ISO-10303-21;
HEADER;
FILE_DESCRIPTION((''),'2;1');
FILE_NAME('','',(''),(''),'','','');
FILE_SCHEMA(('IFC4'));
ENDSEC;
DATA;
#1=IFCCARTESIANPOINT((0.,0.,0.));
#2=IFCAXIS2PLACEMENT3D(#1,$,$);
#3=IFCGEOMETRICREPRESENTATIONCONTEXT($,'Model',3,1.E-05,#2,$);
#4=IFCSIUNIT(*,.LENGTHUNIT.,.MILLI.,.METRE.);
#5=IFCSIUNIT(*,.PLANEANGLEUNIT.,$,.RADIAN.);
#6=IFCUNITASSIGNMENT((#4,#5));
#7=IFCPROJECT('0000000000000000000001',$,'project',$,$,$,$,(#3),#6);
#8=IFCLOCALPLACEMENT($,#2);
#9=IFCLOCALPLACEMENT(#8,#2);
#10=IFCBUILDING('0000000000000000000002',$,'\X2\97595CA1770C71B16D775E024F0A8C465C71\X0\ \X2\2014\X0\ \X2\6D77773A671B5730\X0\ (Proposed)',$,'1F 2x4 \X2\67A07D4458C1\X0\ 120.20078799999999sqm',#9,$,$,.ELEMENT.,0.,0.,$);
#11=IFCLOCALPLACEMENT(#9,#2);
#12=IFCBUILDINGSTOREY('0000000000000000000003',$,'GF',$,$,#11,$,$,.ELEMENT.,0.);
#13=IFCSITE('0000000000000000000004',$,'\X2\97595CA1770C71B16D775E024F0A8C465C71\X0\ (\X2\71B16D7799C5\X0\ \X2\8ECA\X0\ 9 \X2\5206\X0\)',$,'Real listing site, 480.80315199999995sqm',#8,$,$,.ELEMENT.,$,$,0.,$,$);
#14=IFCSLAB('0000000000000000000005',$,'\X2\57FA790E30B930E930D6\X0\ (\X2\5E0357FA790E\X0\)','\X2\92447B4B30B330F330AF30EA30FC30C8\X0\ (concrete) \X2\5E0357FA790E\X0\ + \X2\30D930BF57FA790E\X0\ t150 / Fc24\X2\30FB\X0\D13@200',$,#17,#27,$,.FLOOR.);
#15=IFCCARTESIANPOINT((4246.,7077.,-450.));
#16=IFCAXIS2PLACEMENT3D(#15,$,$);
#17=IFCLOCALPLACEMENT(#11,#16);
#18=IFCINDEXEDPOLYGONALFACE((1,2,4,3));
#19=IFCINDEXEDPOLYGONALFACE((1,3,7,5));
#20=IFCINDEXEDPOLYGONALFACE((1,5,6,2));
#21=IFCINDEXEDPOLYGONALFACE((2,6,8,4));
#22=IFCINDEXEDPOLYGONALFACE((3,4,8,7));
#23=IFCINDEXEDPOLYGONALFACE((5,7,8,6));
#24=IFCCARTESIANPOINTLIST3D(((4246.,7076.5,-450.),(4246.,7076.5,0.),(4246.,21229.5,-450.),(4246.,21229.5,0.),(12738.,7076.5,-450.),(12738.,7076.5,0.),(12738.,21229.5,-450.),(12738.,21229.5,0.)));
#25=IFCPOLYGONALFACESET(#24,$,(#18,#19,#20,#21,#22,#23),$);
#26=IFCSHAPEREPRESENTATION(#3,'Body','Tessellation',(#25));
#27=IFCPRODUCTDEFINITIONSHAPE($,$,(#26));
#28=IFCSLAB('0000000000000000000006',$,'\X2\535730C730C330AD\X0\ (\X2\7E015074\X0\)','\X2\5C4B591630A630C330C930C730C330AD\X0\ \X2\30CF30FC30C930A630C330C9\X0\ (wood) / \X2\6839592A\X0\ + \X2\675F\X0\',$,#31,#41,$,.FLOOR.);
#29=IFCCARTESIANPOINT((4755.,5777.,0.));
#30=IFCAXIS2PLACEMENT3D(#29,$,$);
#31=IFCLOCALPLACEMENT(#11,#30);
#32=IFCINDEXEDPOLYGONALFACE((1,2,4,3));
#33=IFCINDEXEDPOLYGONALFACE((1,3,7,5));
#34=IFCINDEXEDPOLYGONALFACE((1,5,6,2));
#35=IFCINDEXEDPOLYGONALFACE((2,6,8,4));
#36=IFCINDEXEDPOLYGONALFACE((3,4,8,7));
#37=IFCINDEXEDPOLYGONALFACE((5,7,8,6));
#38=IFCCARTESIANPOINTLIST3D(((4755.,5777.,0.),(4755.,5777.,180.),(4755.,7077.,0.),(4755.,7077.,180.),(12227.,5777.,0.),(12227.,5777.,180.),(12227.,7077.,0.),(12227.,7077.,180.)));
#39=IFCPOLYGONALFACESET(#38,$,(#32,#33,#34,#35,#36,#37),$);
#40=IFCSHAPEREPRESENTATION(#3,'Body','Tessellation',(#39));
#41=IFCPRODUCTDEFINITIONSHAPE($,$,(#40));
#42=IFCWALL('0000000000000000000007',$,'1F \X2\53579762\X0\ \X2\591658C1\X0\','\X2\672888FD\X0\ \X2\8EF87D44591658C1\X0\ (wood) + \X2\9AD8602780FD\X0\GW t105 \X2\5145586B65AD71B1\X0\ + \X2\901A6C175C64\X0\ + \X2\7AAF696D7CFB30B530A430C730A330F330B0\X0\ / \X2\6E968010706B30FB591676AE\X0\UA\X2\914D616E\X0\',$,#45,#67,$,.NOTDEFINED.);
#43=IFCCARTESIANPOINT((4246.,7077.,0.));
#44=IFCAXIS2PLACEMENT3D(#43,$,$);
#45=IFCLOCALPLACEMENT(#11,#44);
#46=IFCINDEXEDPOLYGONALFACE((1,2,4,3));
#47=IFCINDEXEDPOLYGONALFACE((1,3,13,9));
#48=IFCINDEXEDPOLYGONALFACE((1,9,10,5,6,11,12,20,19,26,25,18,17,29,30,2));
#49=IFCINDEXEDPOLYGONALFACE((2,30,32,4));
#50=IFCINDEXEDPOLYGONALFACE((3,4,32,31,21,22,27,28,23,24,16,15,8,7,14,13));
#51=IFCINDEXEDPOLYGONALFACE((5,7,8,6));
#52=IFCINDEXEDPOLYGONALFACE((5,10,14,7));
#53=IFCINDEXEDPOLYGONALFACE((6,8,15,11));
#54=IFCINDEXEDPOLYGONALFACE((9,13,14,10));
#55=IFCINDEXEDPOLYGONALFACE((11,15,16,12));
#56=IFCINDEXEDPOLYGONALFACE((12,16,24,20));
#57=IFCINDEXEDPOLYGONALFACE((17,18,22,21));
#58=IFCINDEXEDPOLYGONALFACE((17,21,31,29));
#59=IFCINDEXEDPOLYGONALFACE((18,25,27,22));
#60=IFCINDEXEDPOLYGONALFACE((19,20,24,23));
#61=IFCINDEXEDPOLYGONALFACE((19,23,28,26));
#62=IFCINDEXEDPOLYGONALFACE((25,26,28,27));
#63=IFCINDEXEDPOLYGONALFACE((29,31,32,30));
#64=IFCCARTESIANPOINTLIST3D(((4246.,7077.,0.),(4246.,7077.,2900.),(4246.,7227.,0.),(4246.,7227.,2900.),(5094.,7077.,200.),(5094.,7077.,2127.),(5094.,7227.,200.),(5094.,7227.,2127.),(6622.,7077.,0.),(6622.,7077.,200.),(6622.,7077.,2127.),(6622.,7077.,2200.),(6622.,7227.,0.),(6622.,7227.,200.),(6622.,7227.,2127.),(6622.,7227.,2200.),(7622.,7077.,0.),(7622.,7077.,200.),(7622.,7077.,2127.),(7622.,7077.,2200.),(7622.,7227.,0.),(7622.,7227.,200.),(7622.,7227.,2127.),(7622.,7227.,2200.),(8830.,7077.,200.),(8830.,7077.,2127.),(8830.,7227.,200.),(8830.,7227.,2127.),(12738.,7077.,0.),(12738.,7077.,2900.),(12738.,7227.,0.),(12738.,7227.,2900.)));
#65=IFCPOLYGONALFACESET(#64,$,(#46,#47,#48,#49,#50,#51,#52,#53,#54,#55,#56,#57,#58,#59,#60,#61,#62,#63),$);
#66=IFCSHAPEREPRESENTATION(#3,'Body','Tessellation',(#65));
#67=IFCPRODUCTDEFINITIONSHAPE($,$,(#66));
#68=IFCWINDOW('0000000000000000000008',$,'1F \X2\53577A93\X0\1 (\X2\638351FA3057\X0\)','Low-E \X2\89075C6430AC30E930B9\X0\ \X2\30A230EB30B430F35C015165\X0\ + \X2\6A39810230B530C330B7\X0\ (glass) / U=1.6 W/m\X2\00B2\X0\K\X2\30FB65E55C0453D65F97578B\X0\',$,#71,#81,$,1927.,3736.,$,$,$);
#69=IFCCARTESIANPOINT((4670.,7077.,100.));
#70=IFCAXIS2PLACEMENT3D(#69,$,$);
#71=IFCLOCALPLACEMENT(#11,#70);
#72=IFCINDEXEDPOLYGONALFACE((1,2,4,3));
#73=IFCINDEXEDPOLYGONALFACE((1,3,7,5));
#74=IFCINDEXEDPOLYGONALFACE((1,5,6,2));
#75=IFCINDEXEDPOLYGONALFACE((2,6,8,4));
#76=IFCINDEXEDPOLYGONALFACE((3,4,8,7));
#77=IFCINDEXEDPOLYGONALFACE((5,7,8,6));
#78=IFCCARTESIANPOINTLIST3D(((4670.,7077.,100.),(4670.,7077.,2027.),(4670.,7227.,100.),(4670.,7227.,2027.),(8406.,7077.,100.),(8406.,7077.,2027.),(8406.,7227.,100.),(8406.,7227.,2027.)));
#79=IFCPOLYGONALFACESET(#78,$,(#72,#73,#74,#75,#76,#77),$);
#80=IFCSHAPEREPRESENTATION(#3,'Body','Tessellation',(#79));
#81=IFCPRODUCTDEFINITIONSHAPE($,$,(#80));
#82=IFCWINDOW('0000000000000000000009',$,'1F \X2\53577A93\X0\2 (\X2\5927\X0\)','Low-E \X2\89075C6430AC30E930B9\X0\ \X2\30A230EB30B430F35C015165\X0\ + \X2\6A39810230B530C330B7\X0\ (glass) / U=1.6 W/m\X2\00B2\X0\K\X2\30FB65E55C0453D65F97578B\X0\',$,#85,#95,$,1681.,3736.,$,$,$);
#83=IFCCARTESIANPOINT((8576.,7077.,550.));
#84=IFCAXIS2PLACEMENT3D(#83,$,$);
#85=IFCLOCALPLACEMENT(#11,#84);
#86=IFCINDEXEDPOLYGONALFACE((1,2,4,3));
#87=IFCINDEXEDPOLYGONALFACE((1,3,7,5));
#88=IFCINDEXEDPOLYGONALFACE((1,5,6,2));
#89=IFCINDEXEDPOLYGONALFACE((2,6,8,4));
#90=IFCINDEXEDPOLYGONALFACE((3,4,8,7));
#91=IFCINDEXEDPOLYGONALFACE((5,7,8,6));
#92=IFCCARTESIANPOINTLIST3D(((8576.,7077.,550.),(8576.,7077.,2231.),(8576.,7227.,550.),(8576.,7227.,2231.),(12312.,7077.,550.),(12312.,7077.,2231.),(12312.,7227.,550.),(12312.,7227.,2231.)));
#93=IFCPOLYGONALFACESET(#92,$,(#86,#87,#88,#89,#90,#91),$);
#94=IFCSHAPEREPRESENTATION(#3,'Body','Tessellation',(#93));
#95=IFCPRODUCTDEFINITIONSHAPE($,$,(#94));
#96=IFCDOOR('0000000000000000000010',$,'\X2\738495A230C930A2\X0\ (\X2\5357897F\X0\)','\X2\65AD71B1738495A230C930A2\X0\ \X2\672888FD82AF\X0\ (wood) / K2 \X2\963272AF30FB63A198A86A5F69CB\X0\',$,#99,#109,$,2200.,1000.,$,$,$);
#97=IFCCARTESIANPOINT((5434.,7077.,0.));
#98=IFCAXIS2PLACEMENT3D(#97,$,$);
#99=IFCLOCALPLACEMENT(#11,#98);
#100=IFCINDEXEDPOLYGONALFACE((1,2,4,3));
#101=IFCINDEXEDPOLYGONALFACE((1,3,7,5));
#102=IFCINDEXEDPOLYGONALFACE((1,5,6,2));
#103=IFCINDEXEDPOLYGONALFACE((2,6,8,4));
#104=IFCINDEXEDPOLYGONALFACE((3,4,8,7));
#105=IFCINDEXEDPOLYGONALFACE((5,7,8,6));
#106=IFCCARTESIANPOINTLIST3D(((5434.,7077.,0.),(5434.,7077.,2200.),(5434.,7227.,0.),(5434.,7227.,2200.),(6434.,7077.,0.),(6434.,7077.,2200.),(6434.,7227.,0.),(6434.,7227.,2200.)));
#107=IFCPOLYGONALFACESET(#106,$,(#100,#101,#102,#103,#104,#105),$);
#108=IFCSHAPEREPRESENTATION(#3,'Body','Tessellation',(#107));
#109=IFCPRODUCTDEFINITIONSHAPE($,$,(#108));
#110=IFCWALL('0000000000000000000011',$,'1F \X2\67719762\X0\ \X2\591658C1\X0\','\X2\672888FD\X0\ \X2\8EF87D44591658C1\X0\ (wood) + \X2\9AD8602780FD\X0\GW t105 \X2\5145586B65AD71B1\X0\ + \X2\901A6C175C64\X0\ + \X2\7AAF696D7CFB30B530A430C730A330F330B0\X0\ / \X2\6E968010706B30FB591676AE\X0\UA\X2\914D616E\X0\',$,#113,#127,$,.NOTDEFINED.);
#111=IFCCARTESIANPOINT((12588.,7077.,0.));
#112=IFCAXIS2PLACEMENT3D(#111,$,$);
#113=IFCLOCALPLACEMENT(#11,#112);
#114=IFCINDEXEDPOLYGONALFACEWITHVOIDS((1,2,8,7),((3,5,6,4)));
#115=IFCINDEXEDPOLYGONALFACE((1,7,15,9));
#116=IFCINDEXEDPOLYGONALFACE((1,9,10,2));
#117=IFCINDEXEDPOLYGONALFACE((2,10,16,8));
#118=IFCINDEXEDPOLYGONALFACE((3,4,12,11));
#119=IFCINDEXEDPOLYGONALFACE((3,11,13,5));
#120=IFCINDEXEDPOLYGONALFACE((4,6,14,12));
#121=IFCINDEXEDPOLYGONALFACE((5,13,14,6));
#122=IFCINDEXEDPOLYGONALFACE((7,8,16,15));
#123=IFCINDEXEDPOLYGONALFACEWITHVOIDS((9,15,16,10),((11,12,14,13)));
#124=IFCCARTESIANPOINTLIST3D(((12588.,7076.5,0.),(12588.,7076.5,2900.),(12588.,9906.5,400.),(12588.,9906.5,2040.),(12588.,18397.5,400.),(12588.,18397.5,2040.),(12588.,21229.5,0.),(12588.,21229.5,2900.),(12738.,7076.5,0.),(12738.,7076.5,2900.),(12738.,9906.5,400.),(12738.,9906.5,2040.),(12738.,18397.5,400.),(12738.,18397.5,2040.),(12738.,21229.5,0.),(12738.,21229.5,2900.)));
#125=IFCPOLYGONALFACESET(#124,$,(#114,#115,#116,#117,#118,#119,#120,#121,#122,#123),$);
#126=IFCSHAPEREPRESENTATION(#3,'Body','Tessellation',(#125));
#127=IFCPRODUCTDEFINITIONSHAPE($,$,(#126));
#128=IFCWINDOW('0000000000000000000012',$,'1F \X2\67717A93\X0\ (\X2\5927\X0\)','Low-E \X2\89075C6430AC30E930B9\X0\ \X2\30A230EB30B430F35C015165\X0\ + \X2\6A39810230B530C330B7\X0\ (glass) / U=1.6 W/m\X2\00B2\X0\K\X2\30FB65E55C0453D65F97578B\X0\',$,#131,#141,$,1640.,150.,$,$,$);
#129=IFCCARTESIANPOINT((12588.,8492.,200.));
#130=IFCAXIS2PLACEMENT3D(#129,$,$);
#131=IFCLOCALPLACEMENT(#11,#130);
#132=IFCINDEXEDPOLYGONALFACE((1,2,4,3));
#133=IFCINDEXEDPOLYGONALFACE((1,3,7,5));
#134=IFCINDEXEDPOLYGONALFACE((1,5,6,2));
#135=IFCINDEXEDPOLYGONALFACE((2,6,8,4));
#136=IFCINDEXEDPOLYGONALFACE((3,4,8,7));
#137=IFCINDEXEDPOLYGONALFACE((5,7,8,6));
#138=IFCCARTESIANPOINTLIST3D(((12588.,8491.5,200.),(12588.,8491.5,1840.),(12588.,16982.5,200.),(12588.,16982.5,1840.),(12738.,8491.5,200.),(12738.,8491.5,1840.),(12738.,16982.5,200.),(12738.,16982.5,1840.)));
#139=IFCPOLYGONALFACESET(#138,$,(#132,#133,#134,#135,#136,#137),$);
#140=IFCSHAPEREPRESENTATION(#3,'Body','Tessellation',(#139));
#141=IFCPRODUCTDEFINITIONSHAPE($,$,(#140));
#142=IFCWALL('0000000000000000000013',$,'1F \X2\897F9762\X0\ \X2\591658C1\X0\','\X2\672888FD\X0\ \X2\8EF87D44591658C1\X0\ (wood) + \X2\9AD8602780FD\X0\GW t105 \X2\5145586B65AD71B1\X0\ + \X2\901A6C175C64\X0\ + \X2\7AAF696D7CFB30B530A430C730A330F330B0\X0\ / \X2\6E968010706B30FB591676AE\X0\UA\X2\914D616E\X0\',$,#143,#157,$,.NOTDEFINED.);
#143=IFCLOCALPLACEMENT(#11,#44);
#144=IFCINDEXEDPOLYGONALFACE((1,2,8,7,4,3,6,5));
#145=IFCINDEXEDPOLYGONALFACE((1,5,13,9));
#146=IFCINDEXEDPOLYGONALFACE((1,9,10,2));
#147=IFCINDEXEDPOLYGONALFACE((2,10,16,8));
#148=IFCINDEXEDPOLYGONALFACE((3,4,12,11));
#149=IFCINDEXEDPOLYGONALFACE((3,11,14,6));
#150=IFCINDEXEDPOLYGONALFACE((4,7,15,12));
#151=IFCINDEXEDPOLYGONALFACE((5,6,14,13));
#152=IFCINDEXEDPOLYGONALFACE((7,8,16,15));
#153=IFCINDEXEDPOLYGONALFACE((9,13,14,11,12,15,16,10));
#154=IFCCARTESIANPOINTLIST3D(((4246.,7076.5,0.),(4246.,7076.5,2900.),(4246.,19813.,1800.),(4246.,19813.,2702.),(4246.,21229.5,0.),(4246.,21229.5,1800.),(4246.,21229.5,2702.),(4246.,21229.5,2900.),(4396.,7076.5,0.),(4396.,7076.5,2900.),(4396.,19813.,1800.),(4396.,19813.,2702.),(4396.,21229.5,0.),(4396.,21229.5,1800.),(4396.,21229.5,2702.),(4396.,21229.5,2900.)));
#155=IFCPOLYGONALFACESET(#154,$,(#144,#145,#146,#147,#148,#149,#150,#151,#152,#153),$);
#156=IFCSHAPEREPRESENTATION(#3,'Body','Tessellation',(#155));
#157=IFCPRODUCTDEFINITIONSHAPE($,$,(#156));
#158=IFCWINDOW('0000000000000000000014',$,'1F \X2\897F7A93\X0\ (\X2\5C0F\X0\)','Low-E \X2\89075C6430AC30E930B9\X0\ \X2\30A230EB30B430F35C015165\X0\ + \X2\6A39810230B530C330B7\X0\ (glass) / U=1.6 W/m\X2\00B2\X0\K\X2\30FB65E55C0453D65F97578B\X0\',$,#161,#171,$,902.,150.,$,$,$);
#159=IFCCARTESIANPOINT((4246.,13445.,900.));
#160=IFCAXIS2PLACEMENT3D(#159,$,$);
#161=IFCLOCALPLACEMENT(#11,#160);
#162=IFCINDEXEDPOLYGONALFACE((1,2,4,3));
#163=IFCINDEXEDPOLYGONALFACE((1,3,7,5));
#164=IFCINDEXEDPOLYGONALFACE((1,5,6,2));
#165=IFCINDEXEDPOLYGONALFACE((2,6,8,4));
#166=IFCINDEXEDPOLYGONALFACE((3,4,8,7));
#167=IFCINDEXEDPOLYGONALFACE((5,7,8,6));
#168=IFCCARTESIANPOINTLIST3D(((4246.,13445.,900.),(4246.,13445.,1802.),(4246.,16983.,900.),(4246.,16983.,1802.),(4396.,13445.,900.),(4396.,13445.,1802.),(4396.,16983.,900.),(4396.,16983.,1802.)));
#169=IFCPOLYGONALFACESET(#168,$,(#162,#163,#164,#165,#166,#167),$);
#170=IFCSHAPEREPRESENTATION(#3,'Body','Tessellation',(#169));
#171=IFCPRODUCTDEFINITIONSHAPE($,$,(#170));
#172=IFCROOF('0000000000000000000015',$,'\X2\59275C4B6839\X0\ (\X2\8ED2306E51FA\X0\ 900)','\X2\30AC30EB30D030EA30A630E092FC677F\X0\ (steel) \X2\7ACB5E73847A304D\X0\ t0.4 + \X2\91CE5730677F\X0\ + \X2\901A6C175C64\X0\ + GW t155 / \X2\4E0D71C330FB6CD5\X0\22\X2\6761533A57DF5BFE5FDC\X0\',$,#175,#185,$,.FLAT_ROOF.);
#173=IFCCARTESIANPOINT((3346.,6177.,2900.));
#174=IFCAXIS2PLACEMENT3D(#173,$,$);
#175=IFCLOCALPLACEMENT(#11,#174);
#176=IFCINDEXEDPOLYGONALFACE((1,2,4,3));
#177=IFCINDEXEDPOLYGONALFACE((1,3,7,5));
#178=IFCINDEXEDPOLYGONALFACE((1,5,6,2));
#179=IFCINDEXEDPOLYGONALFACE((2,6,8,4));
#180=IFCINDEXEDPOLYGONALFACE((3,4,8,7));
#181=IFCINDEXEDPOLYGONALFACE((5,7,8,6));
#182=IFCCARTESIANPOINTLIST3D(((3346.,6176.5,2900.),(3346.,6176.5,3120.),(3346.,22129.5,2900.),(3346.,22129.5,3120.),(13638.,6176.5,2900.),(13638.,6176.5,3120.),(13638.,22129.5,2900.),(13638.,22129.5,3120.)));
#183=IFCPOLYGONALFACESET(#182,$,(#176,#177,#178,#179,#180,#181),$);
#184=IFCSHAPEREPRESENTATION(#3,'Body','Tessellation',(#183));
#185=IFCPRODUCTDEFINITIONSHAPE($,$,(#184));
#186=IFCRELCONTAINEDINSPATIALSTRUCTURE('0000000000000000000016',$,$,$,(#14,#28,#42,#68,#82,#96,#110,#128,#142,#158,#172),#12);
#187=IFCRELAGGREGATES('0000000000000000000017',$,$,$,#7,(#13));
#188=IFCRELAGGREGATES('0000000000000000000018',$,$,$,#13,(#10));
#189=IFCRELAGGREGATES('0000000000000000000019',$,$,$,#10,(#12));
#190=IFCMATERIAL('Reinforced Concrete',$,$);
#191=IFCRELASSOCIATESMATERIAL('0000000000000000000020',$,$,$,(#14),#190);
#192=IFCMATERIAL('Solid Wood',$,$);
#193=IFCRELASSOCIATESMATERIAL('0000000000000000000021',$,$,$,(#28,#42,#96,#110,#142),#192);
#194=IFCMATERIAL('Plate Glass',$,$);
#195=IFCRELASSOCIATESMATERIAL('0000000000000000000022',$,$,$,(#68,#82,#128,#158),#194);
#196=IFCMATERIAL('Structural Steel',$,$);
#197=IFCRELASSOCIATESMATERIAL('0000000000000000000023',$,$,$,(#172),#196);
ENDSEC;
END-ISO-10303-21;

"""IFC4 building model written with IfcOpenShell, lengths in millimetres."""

from ifc_helpers import new_model, si_unit, frame, frame_2d, origin, place, context, project, spatial, rectangle, extrude, material, element, fill, save


model = new_model("IFC4")

# Units and contexts
model_context = context("Model", 3, precision=1e-05, world=origin())
ifc_project = project(units=[si_unit("LENGTHUNIT", "METRE", prefix="MILLI"), si_unit("PLANEANGLEUNIT", "RADIAN")], contexts=[model_context])

# Site, building, storey
site_placement = place(None, origin())
site = spatial("IfcSite", under=ifc_project, at=site_placement, Name="静岡県熱海市伊豆山 (熱海駅 車 9 分)", ObjectType="Real listing site, 480.80315199999995sqm", CompositionType="ELEMENT", RefElevation=0.0)
building_placement = place(site_placement, origin())
building = spatial("IfcBuilding", under=site, at=building_placement, Name="静岡県熱海市伊豆山 — 海眺望地 (Proposed)", ObjectType="1F 2x4 枠組壁 120.20078799999999sqm", CompositionType="ELEMENT", ElevationOfRefHeight=0.0, ElevationOfTerrain=0.0)
storey_placement = place(building_placement, origin())
storey = spatial("IfcBuildingStorey", under=building, at=storey_placement, Name="GF", CompositionType="ELEMENT", Elevation=0.0)

# Slabs
ifc_material_1 = material(Name="Reinforced Concrete")
slab_1_placement = place(storey_placement, frame((4246.0, 7077.0, -450.0)))
element("IfcSlab", 1, at=slab_1_placement, inside=storey, material=ifc_material_1, Name="基礎スラブ (布基礎)", Description="鉄筋コンクリート (concrete) 布基礎 + ベタ基礎 t150 / Fc24・D13@200", PredefinedType="FLOOR", context=model_context, shape_type="SweptSolid", body=[
    extrude(rectangle(XDim=8492.0, YDim=14153.0, at=frame_2d((4246.0, 7076.0))), frame((4246.0, 7077.0, -450.0)), (0.0, 0.0, 1.0), 450.0),
])
ifc_material_2 = material(Name="Solid Wood")
slab_2_placement = place(storey_placement, frame((4755.0, 5777.0, 0.0)))
element("IfcSlab", 2, at=slab_2_placement, inside=storey, material=ifc_material_2, Name="南デッキ (縁側)", Description="屋外ウッドデッキ ハードウッド (wood) / 根太 + 束", PredefinedType="FLOOR", context=model_context, shape_type="SweptSolid", body=[
    extrude(rectangle(XDim=7472.0, YDim=1300.0, at=frame_2d((3736.0, 650.0))), frame((4755.0, 5777.0, 0.0)), (0.0, 0.0, 1.0), 180.0),
])

# Wall, openings, windows, door
wall_1_placement = place(storey_placement, frame((4246.0, 7077.0, 0.0)))
wall_1 = element("IfcWall", 3, at=wall_1_placement, inside=storey, material=ifc_material_2, Name="1F 南面 外壁", Description="木製 軸組外壁 (wood) + 高性能GW t105 充填断熱 + 通気層 + 窯業系サイディング / 準耐火・外皮UA配慮", PredefinedType="NOTDEFINED", context=model_context, shape_type="SweptSolid", body=[
    extrude(rectangle(XDim=8492.0, YDim=150.0, at=frame_2d((4246.0, 75.0))), frame((4246.0, 7077.0, 0.0)), (0.0, 0.0, 1.0), 2900.0),
])
opening_1_placement = place(storey_placement, frame((4670.0, 7077.0, 100.0)))
opening_1 = element("IfcOpeningElement", 4, at=opening_1_placement, cuts=wall_1, PredefinedType="NOTDEFINED", context=model_context, shape_type="SweptSolid", body=[
    extrude(rectangle(XDim=3736.0, YDim=150.0, at=frame_2d((1868.0, 75.0))), frame((4670.0, 7077.0, 100.0)), (0.0, 0.0, 1.0), 1927.0),
])
opening_2_placement = place(storey_placement, frame((8576.0, 7077.0, 550.0)))
opening_2 = element("IfcOpeningElement", 5, at=opening_2_placement, cuts=wall_1, PredefinedType="NOTDEFINED", context=model_context, shape_type="SweptSolid", body=[
    extrude(rectangle(XDim=3736.0, YDim=150.0, at=frame_2d((1868.0, 75.0))), frame((8576.0, 7077.0, 550.0)), (0.0, 0.0, 1.0), 1681.0),
])
opening_3_placement = place(storey_placement, frame((5434.0, 7077.0, 0.0)))
opening_3 = element("IfcOpeningElement", 6, at=opening_3_placement, cuts=wall_1, PredefinedType="NOTDEFINED", context=model_context, shape_type="SweptSolid", body=[
    extrude(rectangle(XDim=1000.0, YDim=150.0, at=frame_2d((500.0, 75.0))), frame((5434.0, 7077.0, 0.0)), (0.0, 0.0, 1.0), 2200.0),
])
ifc_material_3 = material(Name="Plate Glass")
window_1_placement = place(storey_placement, frame((4670.0, 7077.0, 100.0)))
window_1 = element("IfcWindow", 7, at=window_1_placement, inside=storey, material=ifc_material_3, Name="1F 南窓1 (掃出し)", Description="Low-E 複層ガラス アルゴン封入 + 樹脂サッシ (glass) / U=1.6 W/m²K・日射取得型", OverallHeight=1927.0, OverallWidth=3736.0, context=model_context, shape_type="SweptSolid", body=[
    extrude(rectangle(XDim=3736.0, YDim=150.0, at=frame_2d((1868.0, 75.0))), frame((4670.0, 7077.0, 100.0)), (0.0, 0.0, 1.0), 1927.0),
])
fill(opening_1, window_1)
window_2_placement = place(storey_placement, frame((8576.0, 7077.0, 550.0)))
window_2 = element("IfcWindow", 8, at=window_2_placement, inside=storey, material=ifc_material_3, Name="1F 南窓2 (大)", Description="Low-E 複層ガラス アルゴン封入 + 樹脂サッシ (glass) / U=1.6 W/m²K・日射取得型", OverallHeight=1681.0, OverallWidth=3736.0, context=model_context, shape_type="SweptSolid", body=[
    extrude(rectangle(XDim=3736.0, YDim=150.0, at=frame_2d((1868.0, 75.0))), frame((8576.0, 7077.0, 550.0)), (0.0, 0.0, 1.0), 1681.0),
])
fill(opening_2, window_2)
door_placement = place(storey_placement, frame((5434.0, 7077.0, 0.0)))
door = element("IfcDoor", 9, at=door_placement, inside=storey, material=ifc_material_2, Name="玄関ドア (南西)", Description="断熱玄関ドア 木製芯 (wood) / K2 防犯・採風機構", OverallHeight=2200.0, OverallWidth=1000.0, context=model_context, shape_type="SweptSolid", body=[
    extrude(rectangle(XDim=1000.0, YDim=150.0, at=frame_2d((500.0, 75.0))), frame((5434.0, 7077.0, 0.0)), (0.0, 0.0, 1.0), 2200.0),
])
fill(opening_3, door)

# Walls, openings, windows
wall_2_placement = place(storey_placement, frame((12588.0, 7077.0, 0.0)))
wall_2 = element("IfcWall", 10, at=wall_2_placement, inside=storey, material=ifc_material_2, Name="1F 東面 外壁", Description="木製 軸組外壁 (wood) + 高性能GW t105 充填断熱 + 通気層 + 窯業系サイディング / 準耐火・外皮UA配慮", PredefinedType="NOTDEFINED", context=model_context, shape_type="SweptSolid", body=[
    extrude(rectangle(XDim=150.0, YDim=14153.0, at=frame_2d((75.0, 7076.0))), frame((12588.0, 7077.0, 0.0)), (0.0, 0.0, 1.0), 2900.0),
])
opening_4_placement = place(storey_placement, frame((12588.0, 8492.0, 200.0)))
opening_4 = element("IfcOpeningElement", 11, at=opening_4_placement, cuts=wall_2, PredefinedType="NOTDEFINED", context=model_context, shape_type="SweptSolid", body=[
    extrude(rectangle(XDim=150.0, YDim=8491.0, at=frame_2d((75.0, 4245.0))), frame((12588.0, 8492.0, 200.0)), (0.0, 0.0, 1.0), 1640.0),
])
window_3_placement = place(storey_placement, frame((12588.0, 8492.0, 200.0)))
window_3 = element("IfcWindow", 12, at=window_3_placement, inside=storey, material=ifc_material_3, Name="1F 東窓 (大)", Description="Low-E 複層ガラス アルゴン封入 + 樹脂サッシ (glass) / U=1.6 W/m²K・日射取得型", OverallHeight=1640.0, OverallWidth=150.0, context=model_context, shape_type="SweptSolid", body=[
    extrude(rectangle(XDim=150.0, YDim=8491.0, at=frame_2d((75.0, 4245.0))), frame((12588.0, 8492.0, 200.0)), (0.0, 0.0, 1.0), 1640.0),
])
fill(opening_4, window_3)
wall_3_placement = place(storey_placement, frame((4246.0, 7077.0, 0.0)))
wall_3 = element("IfcWall", 13, at=wall_3_placement, inside=storey, material=ifc_material_2, Name="1F 西面 外壁", Description="木製 軸組外壁 (wood) + 高性能GW t105 充填断熱 + 通気層 + 窯業系サイディング / 準耐火・外皮UA配慮", PredefinedType="NOTDEFINED", context=model_context, shape_type="SweptSolid", body=[
    extrude(rectangle(XDim=150.0, YDim=14153.0, at=frame_2d((75.0, 7076.0))), frame((4246.0, 7077.0, 0.0)), (0.0, 0.0, 1.0), 2900.0),
])
opening_5_placement = place(storey_placement, frame((4246.0, 13445.0, 900.0)))
opening_5 = element("IfcOpeningElement", 14, at=opening_5_placement, cuts=wall_3, PredefinedType="NOTDEFINED", context=model_context, shape_type="SweptSolid", body=[
    extrude(rectangle(XDim=150.0, YDim=3538.0, at=frame_2d((75.0, 1769.0))), frame((4246.0, 13445.0, 900.0)), (0.0, 0.0, 1.0), 902.0),
])
window_4_placement = place(storey_placement, frame((4246.0, 13445.0, 900.0)))
window_4 = element("IfcWindow", 15, at=window_4_placement, inside=storey, material=ifc_material_3, Name="1F 西窓 (小)", Description="Low-E 複層ガラス アルゴン封入 + 樹脂サッシ (glass) / U=1.6 W/m²K・日射取得型", OverallHeight=902.0, OverallWidth=150.0, context=model_context, shape_type="SweptSolid", body=[
    extrude(rectangle(XDim=150.0, YDim=3538.0, at=frame_2d((75.0, 1769.0))), frame((4246.0, 13445.0, 900.0)), (0.0, 0.0, 1.0), 902.0),
])
fill(opening_5, window_4)

# Roof
ifc_material_4 = material(Name="Structural Steel")
roof_placement = place(storey_placement, frame((3346.0, 6177.0, 2900.0)))
element("IfcRoof", 16, at=roof_placement, inside=storey, material=ifc_material_4, Name="大屋根 (軒の出 900)", Description="ガルバリウム鋼板 (steel) 立平葺き t0.4 + 野地板 + 通気層 + GW t155 / 不燃・法22条区域対応", PredefinedType="FLAT_ROOF", context=model_context, shape_type="SweptSolid", body=[
    extrude(rectangle(XDim=10292.0, YDim=15953.0, at=frame_2d((5146.0, 7976.0))), frame((3346.0, 6177.0, 2900.0)), (0.0, 0.0, 1.0), 220.0),
])

save(model, "model.ifc")
